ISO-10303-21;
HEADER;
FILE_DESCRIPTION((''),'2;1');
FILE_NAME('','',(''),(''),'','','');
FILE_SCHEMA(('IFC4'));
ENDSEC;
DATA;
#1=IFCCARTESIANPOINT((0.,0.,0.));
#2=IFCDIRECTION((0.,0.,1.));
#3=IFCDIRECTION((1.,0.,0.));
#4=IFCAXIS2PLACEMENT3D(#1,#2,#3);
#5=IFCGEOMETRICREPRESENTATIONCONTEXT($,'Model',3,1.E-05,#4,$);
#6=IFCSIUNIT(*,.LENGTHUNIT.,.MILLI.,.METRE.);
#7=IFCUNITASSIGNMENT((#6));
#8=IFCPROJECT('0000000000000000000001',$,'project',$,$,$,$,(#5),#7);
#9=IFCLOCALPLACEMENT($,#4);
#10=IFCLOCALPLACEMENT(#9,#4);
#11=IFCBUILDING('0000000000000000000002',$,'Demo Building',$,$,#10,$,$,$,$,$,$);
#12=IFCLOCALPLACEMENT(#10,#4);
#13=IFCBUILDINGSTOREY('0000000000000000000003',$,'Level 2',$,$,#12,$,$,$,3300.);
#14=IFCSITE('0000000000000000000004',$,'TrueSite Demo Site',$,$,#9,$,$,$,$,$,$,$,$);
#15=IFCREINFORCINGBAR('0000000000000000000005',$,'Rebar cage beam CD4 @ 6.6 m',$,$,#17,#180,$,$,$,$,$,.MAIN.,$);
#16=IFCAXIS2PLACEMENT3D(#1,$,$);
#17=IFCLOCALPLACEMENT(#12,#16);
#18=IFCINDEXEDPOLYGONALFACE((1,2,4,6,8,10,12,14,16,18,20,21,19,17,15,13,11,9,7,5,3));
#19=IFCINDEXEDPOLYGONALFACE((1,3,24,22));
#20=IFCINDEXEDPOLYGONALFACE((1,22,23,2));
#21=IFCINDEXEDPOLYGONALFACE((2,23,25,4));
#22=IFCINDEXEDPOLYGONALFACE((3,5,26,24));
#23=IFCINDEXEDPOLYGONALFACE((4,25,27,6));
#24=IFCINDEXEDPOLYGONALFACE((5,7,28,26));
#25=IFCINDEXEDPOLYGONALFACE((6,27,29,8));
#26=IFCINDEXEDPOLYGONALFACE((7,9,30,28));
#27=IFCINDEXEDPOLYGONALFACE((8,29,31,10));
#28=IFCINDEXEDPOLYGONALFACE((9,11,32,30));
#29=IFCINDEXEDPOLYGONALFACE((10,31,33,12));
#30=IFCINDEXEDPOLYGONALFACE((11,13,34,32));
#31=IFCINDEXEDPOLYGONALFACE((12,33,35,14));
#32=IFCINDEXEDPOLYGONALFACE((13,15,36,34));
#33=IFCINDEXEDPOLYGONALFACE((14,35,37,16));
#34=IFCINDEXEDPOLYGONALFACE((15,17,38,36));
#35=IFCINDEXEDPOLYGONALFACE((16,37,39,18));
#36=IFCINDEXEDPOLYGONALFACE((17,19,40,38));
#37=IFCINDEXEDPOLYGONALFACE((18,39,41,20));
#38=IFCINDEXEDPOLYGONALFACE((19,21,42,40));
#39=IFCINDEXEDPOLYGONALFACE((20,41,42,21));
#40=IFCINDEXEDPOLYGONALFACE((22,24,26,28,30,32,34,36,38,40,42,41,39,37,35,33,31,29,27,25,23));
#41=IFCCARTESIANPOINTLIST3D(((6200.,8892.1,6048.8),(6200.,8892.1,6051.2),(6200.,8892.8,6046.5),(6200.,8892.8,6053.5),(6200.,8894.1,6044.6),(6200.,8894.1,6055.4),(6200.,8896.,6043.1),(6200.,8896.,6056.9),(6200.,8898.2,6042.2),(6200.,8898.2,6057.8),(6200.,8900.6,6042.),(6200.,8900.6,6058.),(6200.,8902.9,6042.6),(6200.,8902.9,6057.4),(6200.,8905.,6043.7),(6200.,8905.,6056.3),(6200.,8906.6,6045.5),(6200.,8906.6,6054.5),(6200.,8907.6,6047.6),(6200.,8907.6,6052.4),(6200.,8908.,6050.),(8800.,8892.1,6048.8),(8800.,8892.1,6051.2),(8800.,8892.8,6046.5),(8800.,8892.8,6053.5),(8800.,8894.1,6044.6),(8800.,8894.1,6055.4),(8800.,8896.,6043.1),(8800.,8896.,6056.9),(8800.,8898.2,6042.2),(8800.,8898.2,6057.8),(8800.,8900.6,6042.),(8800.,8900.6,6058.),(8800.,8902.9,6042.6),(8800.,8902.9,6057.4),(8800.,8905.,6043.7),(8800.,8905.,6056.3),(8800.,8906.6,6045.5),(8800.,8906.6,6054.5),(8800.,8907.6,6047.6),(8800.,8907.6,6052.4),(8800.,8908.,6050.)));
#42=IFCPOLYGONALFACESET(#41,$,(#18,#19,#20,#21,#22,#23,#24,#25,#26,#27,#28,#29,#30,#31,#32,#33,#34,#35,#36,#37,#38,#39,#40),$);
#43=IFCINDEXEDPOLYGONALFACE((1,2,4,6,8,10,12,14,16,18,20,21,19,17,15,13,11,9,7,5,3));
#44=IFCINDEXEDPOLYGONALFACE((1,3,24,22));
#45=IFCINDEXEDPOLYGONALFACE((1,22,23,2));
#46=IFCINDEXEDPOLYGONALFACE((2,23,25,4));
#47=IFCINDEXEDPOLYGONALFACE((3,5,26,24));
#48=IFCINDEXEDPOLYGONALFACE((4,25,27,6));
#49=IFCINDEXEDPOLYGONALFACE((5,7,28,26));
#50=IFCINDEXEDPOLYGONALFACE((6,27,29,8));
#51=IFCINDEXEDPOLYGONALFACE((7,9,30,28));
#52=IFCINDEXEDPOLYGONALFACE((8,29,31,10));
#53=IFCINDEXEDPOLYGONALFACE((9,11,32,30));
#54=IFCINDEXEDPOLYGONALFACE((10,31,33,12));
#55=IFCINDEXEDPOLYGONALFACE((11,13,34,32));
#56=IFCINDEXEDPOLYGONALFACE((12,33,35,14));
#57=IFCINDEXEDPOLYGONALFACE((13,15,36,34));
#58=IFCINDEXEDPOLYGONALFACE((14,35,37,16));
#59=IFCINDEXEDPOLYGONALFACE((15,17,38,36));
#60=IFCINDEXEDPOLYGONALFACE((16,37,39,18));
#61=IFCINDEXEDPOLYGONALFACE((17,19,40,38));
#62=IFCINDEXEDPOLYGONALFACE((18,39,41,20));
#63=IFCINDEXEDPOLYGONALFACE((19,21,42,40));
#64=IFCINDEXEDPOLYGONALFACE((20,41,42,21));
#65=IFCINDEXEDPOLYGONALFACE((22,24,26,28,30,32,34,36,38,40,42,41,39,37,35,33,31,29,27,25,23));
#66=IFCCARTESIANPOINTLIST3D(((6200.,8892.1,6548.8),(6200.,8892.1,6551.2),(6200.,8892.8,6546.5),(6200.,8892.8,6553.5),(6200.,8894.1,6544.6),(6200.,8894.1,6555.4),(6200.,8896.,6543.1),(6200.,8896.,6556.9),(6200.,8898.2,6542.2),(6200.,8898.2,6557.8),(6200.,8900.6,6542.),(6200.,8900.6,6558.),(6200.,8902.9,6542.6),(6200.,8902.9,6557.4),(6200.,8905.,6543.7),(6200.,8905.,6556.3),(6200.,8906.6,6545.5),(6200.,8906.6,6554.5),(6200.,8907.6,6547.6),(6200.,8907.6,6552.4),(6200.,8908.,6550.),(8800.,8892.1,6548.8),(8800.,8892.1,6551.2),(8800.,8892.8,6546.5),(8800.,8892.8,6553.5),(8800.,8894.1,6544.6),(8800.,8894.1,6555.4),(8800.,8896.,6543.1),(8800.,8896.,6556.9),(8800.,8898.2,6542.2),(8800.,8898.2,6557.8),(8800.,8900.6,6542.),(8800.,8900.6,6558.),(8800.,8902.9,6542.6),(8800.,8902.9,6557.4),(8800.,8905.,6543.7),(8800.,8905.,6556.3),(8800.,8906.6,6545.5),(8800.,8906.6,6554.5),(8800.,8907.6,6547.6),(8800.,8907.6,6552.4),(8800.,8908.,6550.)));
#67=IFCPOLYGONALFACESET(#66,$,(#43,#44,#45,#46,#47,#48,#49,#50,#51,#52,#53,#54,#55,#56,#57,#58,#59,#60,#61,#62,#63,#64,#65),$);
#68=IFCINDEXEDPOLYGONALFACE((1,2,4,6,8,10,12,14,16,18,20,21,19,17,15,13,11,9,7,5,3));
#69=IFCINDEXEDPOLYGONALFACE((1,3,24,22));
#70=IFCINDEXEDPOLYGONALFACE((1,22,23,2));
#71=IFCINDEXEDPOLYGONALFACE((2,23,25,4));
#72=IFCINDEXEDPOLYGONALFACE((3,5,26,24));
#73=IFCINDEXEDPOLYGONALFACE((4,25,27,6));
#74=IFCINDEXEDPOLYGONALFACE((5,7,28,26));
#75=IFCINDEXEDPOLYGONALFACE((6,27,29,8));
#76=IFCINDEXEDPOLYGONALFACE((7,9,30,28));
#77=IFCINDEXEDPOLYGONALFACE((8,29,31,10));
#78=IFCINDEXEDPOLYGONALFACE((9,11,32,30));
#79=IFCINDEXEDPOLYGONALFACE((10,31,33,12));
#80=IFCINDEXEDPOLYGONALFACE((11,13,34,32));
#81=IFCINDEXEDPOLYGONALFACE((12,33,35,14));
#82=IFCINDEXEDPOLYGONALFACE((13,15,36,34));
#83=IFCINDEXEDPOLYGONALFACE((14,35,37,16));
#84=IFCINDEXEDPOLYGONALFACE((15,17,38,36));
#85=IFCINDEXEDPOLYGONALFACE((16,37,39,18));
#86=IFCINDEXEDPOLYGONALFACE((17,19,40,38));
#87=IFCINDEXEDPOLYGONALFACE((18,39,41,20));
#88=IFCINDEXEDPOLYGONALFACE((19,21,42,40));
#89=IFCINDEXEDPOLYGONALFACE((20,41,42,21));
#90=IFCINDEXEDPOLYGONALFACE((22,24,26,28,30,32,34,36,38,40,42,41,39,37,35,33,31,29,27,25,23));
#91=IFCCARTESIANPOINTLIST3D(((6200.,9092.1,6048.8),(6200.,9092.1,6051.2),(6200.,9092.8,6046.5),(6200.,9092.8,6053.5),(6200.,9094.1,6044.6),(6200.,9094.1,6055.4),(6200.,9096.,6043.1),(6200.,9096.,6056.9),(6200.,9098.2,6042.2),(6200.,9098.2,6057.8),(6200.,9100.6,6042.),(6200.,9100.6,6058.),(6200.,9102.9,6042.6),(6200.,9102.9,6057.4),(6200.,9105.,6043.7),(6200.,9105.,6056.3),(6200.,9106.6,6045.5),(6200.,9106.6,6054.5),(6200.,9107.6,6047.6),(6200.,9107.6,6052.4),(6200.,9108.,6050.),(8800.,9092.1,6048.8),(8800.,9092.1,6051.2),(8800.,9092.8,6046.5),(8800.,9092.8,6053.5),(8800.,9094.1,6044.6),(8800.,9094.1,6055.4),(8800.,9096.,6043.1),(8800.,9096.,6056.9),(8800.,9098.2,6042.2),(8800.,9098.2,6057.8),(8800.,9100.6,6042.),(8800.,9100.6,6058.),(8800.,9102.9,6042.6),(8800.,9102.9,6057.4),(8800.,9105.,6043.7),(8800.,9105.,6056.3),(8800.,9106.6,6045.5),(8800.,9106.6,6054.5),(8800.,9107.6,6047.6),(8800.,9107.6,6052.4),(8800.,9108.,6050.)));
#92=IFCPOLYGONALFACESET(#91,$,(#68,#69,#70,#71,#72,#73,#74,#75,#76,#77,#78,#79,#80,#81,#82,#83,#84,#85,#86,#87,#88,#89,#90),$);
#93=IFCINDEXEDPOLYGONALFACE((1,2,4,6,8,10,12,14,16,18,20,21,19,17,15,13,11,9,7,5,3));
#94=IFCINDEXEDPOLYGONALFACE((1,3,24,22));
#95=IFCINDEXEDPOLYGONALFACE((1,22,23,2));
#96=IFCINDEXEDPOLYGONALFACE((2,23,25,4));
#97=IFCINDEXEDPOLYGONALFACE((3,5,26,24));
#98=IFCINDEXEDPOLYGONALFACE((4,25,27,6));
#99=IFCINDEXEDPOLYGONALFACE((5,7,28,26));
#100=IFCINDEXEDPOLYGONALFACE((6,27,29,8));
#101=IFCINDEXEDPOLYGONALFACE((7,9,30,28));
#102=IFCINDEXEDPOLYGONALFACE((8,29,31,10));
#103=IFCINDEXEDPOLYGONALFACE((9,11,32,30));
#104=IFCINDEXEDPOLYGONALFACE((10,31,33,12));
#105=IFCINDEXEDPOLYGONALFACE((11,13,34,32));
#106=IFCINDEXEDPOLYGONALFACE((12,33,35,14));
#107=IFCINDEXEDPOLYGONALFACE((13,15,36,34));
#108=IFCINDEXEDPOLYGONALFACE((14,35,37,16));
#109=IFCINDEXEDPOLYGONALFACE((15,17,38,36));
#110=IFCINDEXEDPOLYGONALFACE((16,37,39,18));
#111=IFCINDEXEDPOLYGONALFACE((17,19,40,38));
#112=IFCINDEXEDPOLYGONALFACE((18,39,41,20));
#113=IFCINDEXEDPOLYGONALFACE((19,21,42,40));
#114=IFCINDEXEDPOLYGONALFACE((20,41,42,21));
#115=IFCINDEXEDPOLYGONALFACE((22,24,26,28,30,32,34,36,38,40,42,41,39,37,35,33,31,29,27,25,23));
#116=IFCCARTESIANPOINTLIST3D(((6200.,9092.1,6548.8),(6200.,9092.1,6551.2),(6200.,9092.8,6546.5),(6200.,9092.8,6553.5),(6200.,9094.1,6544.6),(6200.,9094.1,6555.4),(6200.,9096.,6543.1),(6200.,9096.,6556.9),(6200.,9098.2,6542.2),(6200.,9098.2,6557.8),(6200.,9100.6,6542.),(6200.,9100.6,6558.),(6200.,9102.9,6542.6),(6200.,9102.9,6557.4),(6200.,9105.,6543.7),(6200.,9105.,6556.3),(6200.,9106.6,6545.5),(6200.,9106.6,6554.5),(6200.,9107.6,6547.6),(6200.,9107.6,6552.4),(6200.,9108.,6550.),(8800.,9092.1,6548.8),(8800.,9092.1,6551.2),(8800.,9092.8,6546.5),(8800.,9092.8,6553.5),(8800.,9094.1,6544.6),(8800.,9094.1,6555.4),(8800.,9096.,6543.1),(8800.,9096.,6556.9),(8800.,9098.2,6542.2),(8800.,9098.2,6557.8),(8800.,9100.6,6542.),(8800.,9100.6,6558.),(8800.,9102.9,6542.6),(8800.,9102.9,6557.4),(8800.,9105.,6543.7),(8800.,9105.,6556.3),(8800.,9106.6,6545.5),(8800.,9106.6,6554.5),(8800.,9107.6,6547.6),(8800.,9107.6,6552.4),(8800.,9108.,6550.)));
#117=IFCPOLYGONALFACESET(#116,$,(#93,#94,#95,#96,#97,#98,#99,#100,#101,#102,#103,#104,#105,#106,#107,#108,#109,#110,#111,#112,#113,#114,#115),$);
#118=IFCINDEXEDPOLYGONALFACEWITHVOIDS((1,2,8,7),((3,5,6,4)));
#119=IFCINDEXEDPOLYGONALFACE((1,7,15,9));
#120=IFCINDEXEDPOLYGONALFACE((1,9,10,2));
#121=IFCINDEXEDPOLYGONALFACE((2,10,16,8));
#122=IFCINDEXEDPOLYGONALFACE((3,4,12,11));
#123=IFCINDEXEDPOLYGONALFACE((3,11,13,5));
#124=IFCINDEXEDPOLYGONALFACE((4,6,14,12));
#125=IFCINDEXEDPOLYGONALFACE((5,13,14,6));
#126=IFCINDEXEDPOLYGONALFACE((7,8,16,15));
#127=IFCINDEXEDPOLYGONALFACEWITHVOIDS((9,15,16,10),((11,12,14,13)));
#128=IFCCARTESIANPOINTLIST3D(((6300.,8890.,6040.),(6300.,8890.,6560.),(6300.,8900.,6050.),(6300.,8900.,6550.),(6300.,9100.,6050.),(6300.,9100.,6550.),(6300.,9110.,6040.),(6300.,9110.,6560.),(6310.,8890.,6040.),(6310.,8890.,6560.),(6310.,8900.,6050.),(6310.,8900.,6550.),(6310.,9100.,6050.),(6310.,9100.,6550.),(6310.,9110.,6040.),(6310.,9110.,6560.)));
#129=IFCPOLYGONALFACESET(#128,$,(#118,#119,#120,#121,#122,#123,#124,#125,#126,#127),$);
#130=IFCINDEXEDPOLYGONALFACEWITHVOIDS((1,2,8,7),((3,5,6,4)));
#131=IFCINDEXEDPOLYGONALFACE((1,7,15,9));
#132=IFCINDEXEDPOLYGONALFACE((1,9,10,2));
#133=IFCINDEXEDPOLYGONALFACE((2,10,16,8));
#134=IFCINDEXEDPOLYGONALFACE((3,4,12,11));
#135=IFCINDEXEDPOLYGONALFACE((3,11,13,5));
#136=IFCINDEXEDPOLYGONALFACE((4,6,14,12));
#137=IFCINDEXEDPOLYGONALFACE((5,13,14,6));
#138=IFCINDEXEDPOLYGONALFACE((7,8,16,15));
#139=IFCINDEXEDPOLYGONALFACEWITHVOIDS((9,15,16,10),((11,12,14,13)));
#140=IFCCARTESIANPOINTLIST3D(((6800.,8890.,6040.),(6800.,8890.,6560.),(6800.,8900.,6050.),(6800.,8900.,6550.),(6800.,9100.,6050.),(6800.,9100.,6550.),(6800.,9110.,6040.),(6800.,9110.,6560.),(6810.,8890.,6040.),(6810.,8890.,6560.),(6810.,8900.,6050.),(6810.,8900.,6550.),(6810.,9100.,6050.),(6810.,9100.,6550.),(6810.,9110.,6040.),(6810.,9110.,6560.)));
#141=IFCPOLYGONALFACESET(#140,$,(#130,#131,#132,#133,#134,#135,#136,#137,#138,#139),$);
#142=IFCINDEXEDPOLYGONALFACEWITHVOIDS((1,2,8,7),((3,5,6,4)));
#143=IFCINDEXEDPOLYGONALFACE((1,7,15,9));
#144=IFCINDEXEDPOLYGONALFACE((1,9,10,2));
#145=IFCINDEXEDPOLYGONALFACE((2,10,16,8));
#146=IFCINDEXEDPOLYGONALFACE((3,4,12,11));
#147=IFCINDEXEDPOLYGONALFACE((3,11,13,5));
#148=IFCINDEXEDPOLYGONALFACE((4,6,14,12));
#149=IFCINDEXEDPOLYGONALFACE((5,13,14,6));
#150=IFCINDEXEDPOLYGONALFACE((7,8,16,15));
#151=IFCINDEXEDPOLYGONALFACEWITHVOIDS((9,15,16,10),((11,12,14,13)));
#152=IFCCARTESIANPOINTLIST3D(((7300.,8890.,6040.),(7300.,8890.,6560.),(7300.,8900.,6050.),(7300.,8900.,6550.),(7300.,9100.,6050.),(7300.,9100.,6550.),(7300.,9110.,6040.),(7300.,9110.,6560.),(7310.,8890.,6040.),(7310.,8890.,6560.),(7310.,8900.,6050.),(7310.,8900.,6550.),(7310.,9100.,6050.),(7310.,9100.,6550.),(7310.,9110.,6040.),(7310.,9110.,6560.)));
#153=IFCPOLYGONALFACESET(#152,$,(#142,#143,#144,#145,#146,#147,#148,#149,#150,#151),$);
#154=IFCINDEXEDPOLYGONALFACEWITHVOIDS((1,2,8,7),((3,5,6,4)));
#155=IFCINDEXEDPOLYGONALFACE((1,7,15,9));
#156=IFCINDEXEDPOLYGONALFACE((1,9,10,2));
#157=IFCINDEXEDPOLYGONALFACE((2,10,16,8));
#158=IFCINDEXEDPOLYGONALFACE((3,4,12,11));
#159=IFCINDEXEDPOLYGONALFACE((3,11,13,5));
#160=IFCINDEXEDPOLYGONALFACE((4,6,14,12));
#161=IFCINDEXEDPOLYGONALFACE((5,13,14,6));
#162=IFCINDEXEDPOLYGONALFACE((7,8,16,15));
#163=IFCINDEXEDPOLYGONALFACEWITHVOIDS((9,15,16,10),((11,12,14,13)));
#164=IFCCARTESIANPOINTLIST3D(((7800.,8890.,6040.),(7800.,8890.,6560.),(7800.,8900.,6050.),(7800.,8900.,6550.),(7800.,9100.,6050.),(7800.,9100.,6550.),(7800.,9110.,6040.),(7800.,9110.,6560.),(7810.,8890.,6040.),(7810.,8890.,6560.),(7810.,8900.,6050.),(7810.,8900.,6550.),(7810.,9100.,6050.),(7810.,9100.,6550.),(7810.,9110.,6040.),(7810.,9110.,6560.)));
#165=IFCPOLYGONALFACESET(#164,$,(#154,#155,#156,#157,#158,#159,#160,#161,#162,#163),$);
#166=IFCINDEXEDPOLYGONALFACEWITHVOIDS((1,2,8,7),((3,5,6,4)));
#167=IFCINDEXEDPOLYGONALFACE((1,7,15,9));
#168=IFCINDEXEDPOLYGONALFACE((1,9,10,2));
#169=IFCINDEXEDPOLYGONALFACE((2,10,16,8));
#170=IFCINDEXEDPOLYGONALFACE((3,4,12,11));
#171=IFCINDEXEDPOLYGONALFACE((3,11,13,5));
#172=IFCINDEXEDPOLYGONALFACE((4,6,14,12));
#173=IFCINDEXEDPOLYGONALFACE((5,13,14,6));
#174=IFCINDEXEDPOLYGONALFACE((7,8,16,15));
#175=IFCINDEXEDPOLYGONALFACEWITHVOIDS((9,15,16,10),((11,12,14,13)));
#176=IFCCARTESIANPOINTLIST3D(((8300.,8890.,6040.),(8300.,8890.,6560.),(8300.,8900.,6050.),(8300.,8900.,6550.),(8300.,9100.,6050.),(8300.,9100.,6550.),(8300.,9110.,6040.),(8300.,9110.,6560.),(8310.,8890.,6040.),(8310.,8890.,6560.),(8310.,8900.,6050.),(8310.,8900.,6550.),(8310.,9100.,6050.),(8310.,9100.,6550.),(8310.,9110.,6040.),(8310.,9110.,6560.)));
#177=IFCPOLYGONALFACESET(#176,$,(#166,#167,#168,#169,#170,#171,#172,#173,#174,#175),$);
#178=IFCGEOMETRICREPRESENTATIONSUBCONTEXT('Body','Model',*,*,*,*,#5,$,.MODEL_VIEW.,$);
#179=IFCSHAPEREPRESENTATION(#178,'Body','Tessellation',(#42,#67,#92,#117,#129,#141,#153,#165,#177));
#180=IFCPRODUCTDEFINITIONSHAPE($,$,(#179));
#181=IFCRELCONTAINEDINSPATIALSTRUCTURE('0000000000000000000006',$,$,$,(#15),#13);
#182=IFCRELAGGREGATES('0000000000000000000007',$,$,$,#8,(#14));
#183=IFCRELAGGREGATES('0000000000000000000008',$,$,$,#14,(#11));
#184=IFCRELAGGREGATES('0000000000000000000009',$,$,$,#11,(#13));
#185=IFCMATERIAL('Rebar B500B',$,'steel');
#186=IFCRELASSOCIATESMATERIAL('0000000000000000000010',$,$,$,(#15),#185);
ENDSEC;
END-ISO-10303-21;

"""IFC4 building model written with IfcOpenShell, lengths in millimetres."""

from ifc_helpers import new_model, si_unit, frame, origin_with_axes, place, context, subcontext, project, spatial, hollow_rectangle, circle, extrude, material, element, save


model = new_model("IFC4")

# Units and contexts
model_context = context("Model", 3, precision=1e-05, world=origin_with_axes())
body_context = subcontext(model_context, "Body", "Model", "MODEL_VIEW")
ifc_project = project(units=[si_unit("LENGTHUNIT", "METRE", prefix="MILLI")], contexts=[model_context])

# Site, building, storey
site_placement = place(None, origin_with_axes())
site = spatial("IfcSite", under=ifc_project, at=site_placement, Name="TrueSite Demo Site")
building_placement = place(site_placement, origin_with_axes())
building = spatial("IfcBuilding", under=site, at=building_placement, Name="Demo Building")
storey_placement = place(building_placement, origin_with_axes())
storey = spatial("IfcBuildingStorey", under=building, at=storey_placement, Name="Level 2", Elevation=3300.0)

# Reinforcing bar
ifc_material_1 = material(Name="Rebar B500B", Category="steel")
for number, where, z_axis, x_axis, name in (
    (1, (6200.0, 9000.0, 6300.0), (1.0, 0.0, 0.0), (0.0, 1.0, 0.0), "Rebar cage beam CD4 @ 6.6 m"),
):
    element("IfcReinforcingBar", number, at=place(storey_placement, frame(where, z_axis=z_axis, x_axis=x_axis)), inside=storey, material=ifc_material_1, Name=name, PredefinedType="MAIN", context=body_context, shape_type="SweptSolid", body=[
        extrude(circle(Radius=8.0), frame((-100.0, -250.0, 0.0)), (0.0, 0.0, 1.0), 2600.0),
        extrude(circle(Radius=8.0), frame((-100.0, 250.0, 0.0)), (0.0, 0.0, 1.0), 2600.0),
        extrude(circle(Radius=8.0), frame((100.0, -250.0, 0.0)), (0.0, 0.0, 1.0), 2600.0),
        extrude(circle(Radius=8.0), frame((100.0, 250.0, 0.0)), (0.0, 0.0, 1.0), 2600.0),
        extrude(hollow_rectangle(XDim=220.0, YDim=520.0, WallThickness=10.0), frame((0.0, 0.0, 100.0)), (0.0, 0.0, 1.0), 10.0),
        extrude(hollow_rectangle(XDim=220.0, YDim=520.0, WallThickness=10.0), frame((0.0, 0.0, 600.0)), (0.0, 0.0, 1.0), 10.0),
        extrude(hollow_rectangle(XDim=220.0, YDim=520.0, WallThickness=10.0), frame((0.0, 0.0, 1100.0)), (0.0, 0.0, 1.0), 10.0),
        extrude(hollow_rectangle(XDim=220.0, YDim=520.0, WallThickness=10.0), frame((0.0, 0.0, 1600.0)), (0.0, 0.0, 1.0), 10.0),
        extrude(hollow_rectangle(XDim=220.0, YDim=520.0, WallThickness=10.0), frame((0.0, 0.0, 2100.0)), (0.0, 0.0, 1.0), 10.0),
    ])

save(model, "model.ifc")
